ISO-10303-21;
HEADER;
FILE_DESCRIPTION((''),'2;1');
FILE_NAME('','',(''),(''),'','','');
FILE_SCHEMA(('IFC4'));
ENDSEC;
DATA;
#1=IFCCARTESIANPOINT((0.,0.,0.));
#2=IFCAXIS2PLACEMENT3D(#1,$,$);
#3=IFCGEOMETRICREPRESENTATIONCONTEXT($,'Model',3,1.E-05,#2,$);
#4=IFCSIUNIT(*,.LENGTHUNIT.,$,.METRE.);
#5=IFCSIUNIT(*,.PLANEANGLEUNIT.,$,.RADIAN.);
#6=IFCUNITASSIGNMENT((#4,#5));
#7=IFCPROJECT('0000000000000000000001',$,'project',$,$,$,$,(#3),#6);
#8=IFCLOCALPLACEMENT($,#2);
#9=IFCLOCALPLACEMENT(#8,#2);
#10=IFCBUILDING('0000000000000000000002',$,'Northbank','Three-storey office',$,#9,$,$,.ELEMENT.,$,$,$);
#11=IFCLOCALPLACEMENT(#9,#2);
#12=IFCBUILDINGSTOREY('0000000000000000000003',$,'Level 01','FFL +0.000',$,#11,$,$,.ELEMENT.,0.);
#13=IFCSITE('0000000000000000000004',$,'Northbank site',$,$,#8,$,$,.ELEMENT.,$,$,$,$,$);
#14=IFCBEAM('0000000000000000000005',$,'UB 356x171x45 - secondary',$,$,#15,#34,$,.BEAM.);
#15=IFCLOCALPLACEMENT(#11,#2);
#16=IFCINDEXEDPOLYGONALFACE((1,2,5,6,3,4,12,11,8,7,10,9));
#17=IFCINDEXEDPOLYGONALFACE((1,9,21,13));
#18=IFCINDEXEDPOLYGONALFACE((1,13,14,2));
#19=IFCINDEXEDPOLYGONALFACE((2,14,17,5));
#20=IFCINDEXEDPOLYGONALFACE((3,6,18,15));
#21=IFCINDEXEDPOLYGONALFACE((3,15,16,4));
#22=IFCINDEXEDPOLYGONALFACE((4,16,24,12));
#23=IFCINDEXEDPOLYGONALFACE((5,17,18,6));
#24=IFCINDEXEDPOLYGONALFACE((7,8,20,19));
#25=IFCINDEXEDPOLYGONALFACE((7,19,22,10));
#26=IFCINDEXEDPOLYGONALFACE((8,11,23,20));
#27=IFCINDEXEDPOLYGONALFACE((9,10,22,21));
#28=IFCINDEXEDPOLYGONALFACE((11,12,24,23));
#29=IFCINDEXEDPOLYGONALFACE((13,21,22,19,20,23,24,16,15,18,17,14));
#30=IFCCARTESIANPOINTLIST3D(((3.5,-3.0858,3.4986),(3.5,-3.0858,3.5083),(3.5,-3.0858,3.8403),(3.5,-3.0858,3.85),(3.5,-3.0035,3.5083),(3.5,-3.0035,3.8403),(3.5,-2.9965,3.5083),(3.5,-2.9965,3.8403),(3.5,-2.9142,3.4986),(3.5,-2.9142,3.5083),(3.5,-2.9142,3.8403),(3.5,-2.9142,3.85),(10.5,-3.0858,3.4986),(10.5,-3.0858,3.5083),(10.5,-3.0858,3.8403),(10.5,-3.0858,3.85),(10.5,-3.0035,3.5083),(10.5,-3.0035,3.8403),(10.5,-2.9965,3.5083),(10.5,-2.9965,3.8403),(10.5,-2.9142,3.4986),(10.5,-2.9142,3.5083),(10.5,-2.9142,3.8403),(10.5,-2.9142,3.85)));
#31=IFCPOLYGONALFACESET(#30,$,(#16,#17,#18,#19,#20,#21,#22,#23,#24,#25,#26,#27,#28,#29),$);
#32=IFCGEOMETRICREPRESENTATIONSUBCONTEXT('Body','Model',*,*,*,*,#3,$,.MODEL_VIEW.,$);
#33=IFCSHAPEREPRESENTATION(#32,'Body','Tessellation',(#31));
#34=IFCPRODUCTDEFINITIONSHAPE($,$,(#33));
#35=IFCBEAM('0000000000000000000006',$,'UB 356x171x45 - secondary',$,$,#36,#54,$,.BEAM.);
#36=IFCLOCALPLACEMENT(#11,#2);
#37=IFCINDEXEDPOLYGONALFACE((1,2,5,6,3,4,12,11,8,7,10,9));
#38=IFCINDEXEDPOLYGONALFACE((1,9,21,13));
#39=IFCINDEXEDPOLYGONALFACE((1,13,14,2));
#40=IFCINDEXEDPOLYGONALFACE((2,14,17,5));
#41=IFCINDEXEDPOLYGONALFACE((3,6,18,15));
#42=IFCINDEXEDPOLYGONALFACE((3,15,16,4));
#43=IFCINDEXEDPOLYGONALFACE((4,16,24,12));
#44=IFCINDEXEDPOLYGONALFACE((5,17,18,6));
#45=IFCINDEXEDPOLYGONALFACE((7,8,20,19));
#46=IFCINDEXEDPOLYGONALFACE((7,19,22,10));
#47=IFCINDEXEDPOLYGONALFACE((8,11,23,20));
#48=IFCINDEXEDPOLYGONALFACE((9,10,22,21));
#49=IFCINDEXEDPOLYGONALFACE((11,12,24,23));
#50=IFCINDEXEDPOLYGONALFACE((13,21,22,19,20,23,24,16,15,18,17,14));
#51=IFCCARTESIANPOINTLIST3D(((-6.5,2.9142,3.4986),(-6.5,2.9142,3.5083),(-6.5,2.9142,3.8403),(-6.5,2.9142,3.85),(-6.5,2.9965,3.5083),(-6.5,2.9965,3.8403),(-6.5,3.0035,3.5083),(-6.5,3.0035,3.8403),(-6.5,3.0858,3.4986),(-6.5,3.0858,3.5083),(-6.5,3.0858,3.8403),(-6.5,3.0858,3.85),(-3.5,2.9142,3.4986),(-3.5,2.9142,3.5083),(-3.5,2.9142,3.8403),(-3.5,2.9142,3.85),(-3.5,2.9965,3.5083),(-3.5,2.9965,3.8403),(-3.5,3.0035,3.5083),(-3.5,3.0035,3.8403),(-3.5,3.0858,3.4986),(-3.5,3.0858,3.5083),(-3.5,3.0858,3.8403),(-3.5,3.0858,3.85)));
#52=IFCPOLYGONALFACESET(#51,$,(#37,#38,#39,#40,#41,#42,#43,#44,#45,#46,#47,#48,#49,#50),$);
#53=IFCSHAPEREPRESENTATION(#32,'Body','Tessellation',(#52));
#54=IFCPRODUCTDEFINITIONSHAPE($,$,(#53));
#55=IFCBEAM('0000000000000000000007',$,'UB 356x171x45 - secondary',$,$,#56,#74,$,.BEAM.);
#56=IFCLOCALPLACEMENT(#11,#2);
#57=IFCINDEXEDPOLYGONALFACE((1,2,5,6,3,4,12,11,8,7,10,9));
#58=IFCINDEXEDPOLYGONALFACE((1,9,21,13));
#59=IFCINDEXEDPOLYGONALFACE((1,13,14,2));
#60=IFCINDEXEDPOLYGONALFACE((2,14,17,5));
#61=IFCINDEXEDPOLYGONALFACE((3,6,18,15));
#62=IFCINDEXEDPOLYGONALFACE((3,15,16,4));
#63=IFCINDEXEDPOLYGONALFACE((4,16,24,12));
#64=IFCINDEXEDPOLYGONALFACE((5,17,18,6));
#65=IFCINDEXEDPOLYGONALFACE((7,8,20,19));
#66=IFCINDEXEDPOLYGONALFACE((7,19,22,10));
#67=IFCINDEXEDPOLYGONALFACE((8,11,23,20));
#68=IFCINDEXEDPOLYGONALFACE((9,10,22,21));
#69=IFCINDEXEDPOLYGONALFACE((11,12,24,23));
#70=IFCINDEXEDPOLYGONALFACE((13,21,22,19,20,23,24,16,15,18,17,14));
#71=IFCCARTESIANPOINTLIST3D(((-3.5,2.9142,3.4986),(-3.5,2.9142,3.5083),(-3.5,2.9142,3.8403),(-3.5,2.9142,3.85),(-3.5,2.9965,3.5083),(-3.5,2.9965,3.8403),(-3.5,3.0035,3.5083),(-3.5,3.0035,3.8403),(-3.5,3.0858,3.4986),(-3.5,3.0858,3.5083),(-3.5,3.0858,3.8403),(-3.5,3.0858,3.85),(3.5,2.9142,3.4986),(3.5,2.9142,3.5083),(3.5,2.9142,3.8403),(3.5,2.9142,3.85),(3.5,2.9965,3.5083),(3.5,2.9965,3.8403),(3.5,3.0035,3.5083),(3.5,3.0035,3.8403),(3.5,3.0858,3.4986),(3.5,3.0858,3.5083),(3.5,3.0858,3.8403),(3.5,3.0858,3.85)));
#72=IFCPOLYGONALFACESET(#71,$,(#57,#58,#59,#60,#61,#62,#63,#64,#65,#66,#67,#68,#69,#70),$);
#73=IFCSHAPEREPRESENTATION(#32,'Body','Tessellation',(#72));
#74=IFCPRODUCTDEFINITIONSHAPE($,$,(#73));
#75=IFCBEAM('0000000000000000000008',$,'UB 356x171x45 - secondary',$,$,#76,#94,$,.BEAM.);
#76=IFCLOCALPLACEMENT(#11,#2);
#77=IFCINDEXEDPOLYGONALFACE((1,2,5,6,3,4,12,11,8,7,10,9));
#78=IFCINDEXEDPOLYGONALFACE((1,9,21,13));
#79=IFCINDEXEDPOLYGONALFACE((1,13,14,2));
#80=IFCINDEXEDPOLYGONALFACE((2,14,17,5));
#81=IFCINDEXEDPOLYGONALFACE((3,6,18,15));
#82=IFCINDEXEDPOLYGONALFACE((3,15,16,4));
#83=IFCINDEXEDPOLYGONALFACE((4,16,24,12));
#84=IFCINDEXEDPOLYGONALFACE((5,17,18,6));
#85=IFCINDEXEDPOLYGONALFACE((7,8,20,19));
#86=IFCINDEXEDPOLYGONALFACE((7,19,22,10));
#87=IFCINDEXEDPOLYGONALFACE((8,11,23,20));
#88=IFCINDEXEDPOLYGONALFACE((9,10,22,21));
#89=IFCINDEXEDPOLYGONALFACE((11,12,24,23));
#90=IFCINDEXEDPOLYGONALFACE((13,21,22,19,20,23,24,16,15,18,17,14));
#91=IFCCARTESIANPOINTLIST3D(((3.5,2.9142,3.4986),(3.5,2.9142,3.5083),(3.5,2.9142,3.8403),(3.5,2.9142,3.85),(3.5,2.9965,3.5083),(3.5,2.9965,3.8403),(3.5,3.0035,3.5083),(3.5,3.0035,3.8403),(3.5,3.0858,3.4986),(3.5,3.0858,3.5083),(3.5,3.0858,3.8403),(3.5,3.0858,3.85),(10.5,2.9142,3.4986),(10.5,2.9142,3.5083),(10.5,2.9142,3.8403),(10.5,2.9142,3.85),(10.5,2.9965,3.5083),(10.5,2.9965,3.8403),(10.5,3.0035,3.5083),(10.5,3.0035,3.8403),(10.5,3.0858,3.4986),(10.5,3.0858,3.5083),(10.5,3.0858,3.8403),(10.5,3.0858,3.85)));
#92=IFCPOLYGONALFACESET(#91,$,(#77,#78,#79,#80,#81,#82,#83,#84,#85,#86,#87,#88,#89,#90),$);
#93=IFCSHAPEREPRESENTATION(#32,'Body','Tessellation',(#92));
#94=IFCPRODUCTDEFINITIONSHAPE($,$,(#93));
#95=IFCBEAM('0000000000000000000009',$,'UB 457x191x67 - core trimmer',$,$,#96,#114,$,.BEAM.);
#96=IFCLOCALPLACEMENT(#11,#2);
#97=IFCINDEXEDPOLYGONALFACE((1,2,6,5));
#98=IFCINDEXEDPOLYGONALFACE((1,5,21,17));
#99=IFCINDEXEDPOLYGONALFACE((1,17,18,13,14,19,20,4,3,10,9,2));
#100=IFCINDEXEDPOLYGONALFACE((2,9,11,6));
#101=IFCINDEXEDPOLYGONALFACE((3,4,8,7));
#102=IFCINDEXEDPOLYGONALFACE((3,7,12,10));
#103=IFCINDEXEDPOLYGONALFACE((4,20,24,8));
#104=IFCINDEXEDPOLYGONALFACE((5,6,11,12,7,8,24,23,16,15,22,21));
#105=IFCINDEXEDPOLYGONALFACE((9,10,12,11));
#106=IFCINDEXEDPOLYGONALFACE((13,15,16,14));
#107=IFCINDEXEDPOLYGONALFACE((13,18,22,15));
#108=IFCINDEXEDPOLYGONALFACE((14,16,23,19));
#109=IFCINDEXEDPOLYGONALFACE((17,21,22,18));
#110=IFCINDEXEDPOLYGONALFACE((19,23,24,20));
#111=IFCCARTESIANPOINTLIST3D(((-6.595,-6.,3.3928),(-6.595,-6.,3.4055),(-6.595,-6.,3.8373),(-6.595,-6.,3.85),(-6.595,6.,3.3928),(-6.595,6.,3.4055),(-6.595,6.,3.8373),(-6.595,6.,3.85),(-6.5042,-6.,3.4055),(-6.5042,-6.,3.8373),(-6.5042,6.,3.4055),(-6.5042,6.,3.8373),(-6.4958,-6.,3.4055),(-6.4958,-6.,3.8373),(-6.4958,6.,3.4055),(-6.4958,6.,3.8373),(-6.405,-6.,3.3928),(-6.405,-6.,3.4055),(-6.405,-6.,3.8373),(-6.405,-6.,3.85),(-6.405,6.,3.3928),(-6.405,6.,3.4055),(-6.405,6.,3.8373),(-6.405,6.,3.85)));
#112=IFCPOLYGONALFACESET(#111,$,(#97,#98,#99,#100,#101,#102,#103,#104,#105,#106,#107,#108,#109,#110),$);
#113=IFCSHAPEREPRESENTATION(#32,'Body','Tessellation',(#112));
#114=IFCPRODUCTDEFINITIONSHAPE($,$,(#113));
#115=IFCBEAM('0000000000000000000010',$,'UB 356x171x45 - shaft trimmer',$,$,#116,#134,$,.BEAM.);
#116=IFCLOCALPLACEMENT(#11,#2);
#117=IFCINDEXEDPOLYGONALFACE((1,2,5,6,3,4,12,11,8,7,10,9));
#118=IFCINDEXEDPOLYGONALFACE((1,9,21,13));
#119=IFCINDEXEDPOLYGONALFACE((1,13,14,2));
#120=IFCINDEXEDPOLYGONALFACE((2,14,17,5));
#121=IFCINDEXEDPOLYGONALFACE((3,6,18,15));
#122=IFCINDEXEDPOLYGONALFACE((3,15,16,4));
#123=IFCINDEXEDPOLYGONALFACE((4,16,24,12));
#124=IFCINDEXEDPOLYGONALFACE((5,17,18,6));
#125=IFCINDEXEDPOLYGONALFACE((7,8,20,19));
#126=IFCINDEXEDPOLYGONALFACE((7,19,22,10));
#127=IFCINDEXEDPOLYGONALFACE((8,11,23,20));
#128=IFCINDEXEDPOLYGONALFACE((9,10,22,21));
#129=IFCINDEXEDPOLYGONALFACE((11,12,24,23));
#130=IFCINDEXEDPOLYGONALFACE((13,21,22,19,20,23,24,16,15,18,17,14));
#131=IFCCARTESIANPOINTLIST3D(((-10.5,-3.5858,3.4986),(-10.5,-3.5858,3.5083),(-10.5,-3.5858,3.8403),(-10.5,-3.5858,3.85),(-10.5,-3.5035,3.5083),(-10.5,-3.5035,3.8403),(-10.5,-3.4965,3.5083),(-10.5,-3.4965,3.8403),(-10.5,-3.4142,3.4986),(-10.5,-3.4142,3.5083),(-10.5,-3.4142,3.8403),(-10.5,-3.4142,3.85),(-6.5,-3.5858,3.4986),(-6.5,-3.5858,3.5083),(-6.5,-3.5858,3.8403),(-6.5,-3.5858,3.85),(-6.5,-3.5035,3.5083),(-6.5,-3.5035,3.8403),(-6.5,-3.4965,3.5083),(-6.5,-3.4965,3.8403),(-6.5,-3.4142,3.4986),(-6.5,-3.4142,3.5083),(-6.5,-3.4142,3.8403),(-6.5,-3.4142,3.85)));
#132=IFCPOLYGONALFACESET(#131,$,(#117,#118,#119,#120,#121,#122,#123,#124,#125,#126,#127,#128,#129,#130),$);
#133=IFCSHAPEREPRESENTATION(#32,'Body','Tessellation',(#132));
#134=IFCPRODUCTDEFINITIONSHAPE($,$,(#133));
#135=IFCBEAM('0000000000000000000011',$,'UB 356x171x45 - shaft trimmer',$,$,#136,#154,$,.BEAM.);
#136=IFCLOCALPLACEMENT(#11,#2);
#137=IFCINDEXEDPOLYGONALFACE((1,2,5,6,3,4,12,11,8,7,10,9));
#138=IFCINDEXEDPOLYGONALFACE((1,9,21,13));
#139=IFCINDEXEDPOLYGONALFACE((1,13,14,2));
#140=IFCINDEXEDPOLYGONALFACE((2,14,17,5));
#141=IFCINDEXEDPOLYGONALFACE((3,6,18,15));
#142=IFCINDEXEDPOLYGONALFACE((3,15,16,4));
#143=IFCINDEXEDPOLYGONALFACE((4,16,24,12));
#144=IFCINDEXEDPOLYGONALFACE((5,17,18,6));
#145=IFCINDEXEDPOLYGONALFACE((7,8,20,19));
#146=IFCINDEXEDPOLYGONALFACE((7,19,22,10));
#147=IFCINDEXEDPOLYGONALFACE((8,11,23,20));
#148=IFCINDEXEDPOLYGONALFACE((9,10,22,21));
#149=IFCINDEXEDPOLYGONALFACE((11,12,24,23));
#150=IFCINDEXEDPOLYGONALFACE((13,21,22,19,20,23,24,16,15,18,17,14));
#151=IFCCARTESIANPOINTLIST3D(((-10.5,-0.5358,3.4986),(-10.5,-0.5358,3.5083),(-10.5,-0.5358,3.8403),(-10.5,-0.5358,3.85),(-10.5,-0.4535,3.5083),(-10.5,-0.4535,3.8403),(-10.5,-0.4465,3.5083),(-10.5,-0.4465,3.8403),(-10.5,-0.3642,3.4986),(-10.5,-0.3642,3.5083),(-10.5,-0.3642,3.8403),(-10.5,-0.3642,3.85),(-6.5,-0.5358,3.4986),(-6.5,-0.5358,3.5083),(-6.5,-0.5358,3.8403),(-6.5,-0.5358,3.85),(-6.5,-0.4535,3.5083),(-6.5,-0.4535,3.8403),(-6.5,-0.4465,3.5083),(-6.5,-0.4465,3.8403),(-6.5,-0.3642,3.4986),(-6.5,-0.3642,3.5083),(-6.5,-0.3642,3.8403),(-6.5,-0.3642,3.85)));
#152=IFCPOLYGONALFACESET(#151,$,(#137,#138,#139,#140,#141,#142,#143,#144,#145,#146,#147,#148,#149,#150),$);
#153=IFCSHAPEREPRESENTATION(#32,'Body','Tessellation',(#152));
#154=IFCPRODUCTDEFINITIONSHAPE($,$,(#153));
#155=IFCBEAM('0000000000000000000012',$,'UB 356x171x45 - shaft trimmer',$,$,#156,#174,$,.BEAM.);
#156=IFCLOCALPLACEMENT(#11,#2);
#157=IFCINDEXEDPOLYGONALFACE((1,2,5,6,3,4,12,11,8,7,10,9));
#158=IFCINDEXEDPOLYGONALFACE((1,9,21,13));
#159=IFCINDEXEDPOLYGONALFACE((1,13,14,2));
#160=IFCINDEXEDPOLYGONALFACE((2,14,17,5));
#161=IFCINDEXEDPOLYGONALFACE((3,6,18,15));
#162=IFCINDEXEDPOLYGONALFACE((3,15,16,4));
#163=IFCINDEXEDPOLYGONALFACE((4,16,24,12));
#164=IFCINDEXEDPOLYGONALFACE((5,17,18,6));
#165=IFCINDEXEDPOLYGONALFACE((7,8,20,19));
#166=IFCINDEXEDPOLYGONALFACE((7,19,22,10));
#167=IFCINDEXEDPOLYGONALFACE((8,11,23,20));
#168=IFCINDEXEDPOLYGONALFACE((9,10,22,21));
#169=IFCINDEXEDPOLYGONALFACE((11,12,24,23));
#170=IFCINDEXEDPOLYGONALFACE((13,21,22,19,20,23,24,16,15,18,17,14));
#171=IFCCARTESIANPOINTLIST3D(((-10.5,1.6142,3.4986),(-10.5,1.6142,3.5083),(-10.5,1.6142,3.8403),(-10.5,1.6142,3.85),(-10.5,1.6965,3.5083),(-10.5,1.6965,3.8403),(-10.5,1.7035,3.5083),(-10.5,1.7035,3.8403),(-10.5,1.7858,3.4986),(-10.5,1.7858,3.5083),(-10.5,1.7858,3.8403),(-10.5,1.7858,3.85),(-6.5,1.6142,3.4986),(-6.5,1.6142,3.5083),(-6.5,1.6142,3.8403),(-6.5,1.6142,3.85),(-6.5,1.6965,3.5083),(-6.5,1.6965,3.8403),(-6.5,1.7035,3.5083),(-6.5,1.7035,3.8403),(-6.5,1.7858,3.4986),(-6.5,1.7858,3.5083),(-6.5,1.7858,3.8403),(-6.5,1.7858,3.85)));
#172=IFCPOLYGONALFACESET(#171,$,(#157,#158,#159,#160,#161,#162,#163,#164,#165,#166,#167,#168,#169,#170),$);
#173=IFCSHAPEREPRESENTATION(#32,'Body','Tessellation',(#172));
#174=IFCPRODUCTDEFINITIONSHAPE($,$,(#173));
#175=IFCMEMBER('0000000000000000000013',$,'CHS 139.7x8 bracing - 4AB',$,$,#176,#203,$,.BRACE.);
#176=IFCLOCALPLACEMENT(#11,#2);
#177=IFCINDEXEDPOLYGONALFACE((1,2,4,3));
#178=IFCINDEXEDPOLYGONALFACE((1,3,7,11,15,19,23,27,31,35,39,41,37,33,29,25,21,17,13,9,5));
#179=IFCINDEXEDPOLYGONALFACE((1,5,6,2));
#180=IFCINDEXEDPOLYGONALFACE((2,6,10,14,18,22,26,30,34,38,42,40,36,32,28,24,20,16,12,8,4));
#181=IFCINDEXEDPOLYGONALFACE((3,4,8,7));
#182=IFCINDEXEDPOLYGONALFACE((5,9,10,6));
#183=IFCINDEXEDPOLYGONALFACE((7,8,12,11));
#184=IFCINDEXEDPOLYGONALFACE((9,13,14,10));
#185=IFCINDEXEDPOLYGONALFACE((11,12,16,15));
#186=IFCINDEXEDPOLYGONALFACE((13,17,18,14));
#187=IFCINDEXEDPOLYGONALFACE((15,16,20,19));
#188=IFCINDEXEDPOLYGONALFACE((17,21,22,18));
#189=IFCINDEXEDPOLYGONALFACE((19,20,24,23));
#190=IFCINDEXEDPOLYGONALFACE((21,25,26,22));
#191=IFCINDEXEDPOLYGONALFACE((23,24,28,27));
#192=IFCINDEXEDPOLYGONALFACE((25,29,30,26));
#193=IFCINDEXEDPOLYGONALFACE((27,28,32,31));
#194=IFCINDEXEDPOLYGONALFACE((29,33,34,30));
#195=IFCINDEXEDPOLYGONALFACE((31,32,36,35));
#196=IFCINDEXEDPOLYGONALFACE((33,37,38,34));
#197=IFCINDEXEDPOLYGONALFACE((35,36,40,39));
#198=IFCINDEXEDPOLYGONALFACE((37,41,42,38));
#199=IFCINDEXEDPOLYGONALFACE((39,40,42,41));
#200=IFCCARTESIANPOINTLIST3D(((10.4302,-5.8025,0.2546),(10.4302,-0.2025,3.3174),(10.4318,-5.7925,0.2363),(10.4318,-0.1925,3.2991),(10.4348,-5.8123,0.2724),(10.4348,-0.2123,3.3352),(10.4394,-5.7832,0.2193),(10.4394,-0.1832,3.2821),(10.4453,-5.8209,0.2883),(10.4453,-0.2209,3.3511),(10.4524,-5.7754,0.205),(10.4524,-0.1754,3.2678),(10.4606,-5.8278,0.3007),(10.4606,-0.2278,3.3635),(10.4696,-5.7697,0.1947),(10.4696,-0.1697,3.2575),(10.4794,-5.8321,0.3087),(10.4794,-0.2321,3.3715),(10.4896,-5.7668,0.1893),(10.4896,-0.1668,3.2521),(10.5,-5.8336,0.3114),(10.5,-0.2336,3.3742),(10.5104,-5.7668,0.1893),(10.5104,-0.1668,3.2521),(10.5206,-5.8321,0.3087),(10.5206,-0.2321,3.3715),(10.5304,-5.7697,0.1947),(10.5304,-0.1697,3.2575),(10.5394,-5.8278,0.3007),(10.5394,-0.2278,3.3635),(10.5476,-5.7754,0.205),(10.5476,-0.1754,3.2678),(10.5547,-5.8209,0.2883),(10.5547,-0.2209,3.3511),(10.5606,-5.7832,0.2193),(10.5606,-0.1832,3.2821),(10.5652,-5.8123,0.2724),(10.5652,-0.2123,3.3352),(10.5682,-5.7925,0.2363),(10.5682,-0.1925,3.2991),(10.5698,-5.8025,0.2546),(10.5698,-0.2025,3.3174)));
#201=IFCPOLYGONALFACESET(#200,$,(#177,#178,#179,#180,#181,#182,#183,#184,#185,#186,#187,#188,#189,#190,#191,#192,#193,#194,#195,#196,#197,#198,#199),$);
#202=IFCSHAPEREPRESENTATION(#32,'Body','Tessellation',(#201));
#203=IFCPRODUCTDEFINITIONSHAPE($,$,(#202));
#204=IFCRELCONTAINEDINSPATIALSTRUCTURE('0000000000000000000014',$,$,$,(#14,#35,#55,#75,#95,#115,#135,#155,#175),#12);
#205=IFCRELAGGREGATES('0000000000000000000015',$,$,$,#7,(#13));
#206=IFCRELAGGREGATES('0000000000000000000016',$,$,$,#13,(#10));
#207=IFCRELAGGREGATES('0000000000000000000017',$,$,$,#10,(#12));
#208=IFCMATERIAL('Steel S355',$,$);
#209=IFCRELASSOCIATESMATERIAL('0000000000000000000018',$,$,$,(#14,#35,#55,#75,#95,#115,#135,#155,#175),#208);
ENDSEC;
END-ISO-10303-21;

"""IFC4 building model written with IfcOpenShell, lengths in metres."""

from ifc_helpers import new_model, si_unit, frame, origin, place, context, subcontext, project, spatial, circle, i_section, extrude, material, element, save


model = new_model("IFC4")

# Units and contexts
model_context = context("Model", 3, precision=1e-05, world=origin())
body_context = subcontext(model_context, "Body", "Model", "MODEL_VIEW")
ifc_project = project(units=[si_unit("LENGTHUNIT", "METRE"), si_unit("PLANEANGLEUNIT", "RADIAN")], contexts=[model_context])

# Site, building, storey
site_placement = place(None, origin())
site = spatial("IfcSite", under=ifc_project, at=site_placement, Name="Northbank site", CompositionType="ELEMENT")
building_placement = place(site_placement, origin())
building = spatial("IfcBuilding", under=site, at=building_placement, Name="Northbank", Description="Three-storey office", CompositionType="ELEMENT")
storey_placement = place(building_placement, origin())
storey = spatial("IfcBuildingStorey", under=building, at=storey_placement, Name="Level 01", Description="FFL +0.000", CompositionType="ELEMENT", Elevation=0.0)

# Beams
ifc_material = material(Name="Steel S355")
beam_1_placement = place(storey_placement, origin())
element("IfcBeam", 1, at=beam_1_placement, inside=storey, material=ifc_material, Name="UB 356x171x45 - secondary", PredefinedType="BEAM", context=body_context, shape_type="SweptSolid", body=[
    extrude(i_section(OverallWidth=0.1715, OverallDepth=0.3514, WebThickness=0.007, FlangeThickness=0.0097), frame((3.5, -3.0, 3.6743), z_axis=(1.0, 0.0, 0.0), x_axis=(0.0, 1.0, 0.0)), (0.0, 0.0, 1.0), 7.0),
])
beam_2_placement = place(storey_placement, origin())
element("IfcBeam", 2, at=beam_2_placement, inside=storey, material=ifc_material, Name="UB 356x171x45 - secondary", PredefinedType="BEAM", context=body_context, shape_type="SweptSolid", body=[
    extrude(i_section(OverallWidth=0.1715, OverallDepth=0.3514, WebThickness=0.007, FlangeThickness=0.0097), frame((-6.5, 3.0, 3.6743), z_axis=(1.0, 0.0, 0.0), x_axis=(0.0, 1.0, 0.0)), (0.0, 0.0, 1.0), 3.0),
])
beam_3_placement = place(storey_placement, origin())
element("IfcBeam", 3, at=beam_3_placement, inside=storey, material=ifc_material, Name="UB 356x171x45 - secondary", PredefinedType="BEAM", context=body_context, shape_type="SweptSolid", body=[
    extrude(i_section(OverallWidth=0.1715, OverallDepth=0.3514, WebThickness=0.007, FlangeThickness=0.0097), frame((-3.5, 3.0, 3.6743), z_axis=(1.0, 0.0, 0.0), x_axis=(0.0, 1.0, 0.0)), (0.0, 0.0, 1.0), 7.0),
])
beam_4_placement = place(storey_placement, origin())
element("IfcBeam", 4, at=beam_4_placement, inside=storey, material=ifc_material, Name="UB 356x171x45 - secondary", PredefinedType="BEAM", context=body_context, shape_type="SweptSolid", body=[
    extrude(i_section(OverallWidth=0.1715, OverallDepth=0.3514, WebThickness=0.007, FlangeThickness=0.0097), frame((3.5, 3.0, 3.6743), z_axis=(1.0, 0.0, 0.0), x_axis=(0.0, 1.0, 0.0)), (0.0, 0.0, 1.0), 7.0),
])
beam_5_placement = place(storey_placement, origin())
element("IfcBeam", 5, at=beam_5_placement, inside=storey, material=ifc_material, Name="UB 457x191x67 - core trimmer", PredefinedType="BEAM", context=body_context, shape_type="SweptSolid", body=[
    extrude(i_section(OverallWidth=0.1899, OverallDepth=0.4572, WebThickness=0.0085, FlangeThickness=0.0127), frame((-6.5, -6.0, 3.6214), z_axis=(0.0, 1.0, 0.0), x_axis=(-1.0, 0.0, 0.0)), (0.0, 0.0, 1.0), 12.0),
])
beam_6_placement = place(storey_placement, origin())
element("IfcBeam", 6, at=beam_6_placement, inside=storey, material=ifc_material, Name="UB 356x171x45 - shaft trimmer", PredefinedType="BEAM", context=body_context, shape_type="SweptSolid", body=[
    extrude(i_section(OverallWidth=0.1715, OverallDepth=0.3514, WebThickness=0.007, FlangeThickness=0.0097), frame((-10.5, -3.5, 3.6743), z_axis=(1.0, 0.0, 0.0), x_axis=(0.0, 1.0, 0.0)), (0.0, 0.0, 1.0), 4.0),
])
beam_7_placement = place(storey_placement, origin())
element("IfcBeam", 7, at=beam_7_placement, inside=storey, material=ifc_material, Name="UB 356x171x45 - shaft trimmer", PredefinedType="BEAM", context=body_context, shape_type="SweptSolid", body=[
    extrude(i_section(OverallWidth=0.1715, OverallDepth=0.3514, WebThickness=0.007, FlangeThickness=0.0097), frame((-10.5, -0.45, 3.6743), z_axis=(1.0, 0.0, 0.0), x_axis=(0.0, 1.0, 0.0)), (0.0, 0.0, 1.0), 4.0),
])
beam_8_placement = place(storey_placement, origin())
element("IfcBeam", 8, at=beam_8_placement, inside=storey, material=ifc_material, Name="UB 356x171x45 - shaft trimmer", PredefinedType="BEAM", context=body_context, shape_type="SweptSolid", body=[
    extrude(i_section(OverallWidth=0.1715, OverallDepth=0.3514, WebThickness=0.007, FlangeThickness=0.0097), frame((-10.5, 1.7, 3.6743), z_axis=(1.0, 0.0, 0.0), x_axis=(0.0, 1.0, 0.0)), (0.0, 0.0, 1.0), 4.0),
])

# Member
member_1_placement = place(storey_placement, origin())
element("IfcMember", 9, at=member_1_placement, inside=storey, material=ifc_material, Name="CHS 139.7x8 bracing - 4AB", PredefinedType="BRACE", context=body_context, shape_type="SweptSolid", body=[
    extrude(circle(Radius=0.07), frame((10.5, -5.8, 0.25), z_axis=(0.0, 0.877351, 0.479849), x_axis=(0.0, -0.479849, 0.877351)), (0.0, 0.0, 1.0), 6.3828),
])

save(model, "model.ifc")
